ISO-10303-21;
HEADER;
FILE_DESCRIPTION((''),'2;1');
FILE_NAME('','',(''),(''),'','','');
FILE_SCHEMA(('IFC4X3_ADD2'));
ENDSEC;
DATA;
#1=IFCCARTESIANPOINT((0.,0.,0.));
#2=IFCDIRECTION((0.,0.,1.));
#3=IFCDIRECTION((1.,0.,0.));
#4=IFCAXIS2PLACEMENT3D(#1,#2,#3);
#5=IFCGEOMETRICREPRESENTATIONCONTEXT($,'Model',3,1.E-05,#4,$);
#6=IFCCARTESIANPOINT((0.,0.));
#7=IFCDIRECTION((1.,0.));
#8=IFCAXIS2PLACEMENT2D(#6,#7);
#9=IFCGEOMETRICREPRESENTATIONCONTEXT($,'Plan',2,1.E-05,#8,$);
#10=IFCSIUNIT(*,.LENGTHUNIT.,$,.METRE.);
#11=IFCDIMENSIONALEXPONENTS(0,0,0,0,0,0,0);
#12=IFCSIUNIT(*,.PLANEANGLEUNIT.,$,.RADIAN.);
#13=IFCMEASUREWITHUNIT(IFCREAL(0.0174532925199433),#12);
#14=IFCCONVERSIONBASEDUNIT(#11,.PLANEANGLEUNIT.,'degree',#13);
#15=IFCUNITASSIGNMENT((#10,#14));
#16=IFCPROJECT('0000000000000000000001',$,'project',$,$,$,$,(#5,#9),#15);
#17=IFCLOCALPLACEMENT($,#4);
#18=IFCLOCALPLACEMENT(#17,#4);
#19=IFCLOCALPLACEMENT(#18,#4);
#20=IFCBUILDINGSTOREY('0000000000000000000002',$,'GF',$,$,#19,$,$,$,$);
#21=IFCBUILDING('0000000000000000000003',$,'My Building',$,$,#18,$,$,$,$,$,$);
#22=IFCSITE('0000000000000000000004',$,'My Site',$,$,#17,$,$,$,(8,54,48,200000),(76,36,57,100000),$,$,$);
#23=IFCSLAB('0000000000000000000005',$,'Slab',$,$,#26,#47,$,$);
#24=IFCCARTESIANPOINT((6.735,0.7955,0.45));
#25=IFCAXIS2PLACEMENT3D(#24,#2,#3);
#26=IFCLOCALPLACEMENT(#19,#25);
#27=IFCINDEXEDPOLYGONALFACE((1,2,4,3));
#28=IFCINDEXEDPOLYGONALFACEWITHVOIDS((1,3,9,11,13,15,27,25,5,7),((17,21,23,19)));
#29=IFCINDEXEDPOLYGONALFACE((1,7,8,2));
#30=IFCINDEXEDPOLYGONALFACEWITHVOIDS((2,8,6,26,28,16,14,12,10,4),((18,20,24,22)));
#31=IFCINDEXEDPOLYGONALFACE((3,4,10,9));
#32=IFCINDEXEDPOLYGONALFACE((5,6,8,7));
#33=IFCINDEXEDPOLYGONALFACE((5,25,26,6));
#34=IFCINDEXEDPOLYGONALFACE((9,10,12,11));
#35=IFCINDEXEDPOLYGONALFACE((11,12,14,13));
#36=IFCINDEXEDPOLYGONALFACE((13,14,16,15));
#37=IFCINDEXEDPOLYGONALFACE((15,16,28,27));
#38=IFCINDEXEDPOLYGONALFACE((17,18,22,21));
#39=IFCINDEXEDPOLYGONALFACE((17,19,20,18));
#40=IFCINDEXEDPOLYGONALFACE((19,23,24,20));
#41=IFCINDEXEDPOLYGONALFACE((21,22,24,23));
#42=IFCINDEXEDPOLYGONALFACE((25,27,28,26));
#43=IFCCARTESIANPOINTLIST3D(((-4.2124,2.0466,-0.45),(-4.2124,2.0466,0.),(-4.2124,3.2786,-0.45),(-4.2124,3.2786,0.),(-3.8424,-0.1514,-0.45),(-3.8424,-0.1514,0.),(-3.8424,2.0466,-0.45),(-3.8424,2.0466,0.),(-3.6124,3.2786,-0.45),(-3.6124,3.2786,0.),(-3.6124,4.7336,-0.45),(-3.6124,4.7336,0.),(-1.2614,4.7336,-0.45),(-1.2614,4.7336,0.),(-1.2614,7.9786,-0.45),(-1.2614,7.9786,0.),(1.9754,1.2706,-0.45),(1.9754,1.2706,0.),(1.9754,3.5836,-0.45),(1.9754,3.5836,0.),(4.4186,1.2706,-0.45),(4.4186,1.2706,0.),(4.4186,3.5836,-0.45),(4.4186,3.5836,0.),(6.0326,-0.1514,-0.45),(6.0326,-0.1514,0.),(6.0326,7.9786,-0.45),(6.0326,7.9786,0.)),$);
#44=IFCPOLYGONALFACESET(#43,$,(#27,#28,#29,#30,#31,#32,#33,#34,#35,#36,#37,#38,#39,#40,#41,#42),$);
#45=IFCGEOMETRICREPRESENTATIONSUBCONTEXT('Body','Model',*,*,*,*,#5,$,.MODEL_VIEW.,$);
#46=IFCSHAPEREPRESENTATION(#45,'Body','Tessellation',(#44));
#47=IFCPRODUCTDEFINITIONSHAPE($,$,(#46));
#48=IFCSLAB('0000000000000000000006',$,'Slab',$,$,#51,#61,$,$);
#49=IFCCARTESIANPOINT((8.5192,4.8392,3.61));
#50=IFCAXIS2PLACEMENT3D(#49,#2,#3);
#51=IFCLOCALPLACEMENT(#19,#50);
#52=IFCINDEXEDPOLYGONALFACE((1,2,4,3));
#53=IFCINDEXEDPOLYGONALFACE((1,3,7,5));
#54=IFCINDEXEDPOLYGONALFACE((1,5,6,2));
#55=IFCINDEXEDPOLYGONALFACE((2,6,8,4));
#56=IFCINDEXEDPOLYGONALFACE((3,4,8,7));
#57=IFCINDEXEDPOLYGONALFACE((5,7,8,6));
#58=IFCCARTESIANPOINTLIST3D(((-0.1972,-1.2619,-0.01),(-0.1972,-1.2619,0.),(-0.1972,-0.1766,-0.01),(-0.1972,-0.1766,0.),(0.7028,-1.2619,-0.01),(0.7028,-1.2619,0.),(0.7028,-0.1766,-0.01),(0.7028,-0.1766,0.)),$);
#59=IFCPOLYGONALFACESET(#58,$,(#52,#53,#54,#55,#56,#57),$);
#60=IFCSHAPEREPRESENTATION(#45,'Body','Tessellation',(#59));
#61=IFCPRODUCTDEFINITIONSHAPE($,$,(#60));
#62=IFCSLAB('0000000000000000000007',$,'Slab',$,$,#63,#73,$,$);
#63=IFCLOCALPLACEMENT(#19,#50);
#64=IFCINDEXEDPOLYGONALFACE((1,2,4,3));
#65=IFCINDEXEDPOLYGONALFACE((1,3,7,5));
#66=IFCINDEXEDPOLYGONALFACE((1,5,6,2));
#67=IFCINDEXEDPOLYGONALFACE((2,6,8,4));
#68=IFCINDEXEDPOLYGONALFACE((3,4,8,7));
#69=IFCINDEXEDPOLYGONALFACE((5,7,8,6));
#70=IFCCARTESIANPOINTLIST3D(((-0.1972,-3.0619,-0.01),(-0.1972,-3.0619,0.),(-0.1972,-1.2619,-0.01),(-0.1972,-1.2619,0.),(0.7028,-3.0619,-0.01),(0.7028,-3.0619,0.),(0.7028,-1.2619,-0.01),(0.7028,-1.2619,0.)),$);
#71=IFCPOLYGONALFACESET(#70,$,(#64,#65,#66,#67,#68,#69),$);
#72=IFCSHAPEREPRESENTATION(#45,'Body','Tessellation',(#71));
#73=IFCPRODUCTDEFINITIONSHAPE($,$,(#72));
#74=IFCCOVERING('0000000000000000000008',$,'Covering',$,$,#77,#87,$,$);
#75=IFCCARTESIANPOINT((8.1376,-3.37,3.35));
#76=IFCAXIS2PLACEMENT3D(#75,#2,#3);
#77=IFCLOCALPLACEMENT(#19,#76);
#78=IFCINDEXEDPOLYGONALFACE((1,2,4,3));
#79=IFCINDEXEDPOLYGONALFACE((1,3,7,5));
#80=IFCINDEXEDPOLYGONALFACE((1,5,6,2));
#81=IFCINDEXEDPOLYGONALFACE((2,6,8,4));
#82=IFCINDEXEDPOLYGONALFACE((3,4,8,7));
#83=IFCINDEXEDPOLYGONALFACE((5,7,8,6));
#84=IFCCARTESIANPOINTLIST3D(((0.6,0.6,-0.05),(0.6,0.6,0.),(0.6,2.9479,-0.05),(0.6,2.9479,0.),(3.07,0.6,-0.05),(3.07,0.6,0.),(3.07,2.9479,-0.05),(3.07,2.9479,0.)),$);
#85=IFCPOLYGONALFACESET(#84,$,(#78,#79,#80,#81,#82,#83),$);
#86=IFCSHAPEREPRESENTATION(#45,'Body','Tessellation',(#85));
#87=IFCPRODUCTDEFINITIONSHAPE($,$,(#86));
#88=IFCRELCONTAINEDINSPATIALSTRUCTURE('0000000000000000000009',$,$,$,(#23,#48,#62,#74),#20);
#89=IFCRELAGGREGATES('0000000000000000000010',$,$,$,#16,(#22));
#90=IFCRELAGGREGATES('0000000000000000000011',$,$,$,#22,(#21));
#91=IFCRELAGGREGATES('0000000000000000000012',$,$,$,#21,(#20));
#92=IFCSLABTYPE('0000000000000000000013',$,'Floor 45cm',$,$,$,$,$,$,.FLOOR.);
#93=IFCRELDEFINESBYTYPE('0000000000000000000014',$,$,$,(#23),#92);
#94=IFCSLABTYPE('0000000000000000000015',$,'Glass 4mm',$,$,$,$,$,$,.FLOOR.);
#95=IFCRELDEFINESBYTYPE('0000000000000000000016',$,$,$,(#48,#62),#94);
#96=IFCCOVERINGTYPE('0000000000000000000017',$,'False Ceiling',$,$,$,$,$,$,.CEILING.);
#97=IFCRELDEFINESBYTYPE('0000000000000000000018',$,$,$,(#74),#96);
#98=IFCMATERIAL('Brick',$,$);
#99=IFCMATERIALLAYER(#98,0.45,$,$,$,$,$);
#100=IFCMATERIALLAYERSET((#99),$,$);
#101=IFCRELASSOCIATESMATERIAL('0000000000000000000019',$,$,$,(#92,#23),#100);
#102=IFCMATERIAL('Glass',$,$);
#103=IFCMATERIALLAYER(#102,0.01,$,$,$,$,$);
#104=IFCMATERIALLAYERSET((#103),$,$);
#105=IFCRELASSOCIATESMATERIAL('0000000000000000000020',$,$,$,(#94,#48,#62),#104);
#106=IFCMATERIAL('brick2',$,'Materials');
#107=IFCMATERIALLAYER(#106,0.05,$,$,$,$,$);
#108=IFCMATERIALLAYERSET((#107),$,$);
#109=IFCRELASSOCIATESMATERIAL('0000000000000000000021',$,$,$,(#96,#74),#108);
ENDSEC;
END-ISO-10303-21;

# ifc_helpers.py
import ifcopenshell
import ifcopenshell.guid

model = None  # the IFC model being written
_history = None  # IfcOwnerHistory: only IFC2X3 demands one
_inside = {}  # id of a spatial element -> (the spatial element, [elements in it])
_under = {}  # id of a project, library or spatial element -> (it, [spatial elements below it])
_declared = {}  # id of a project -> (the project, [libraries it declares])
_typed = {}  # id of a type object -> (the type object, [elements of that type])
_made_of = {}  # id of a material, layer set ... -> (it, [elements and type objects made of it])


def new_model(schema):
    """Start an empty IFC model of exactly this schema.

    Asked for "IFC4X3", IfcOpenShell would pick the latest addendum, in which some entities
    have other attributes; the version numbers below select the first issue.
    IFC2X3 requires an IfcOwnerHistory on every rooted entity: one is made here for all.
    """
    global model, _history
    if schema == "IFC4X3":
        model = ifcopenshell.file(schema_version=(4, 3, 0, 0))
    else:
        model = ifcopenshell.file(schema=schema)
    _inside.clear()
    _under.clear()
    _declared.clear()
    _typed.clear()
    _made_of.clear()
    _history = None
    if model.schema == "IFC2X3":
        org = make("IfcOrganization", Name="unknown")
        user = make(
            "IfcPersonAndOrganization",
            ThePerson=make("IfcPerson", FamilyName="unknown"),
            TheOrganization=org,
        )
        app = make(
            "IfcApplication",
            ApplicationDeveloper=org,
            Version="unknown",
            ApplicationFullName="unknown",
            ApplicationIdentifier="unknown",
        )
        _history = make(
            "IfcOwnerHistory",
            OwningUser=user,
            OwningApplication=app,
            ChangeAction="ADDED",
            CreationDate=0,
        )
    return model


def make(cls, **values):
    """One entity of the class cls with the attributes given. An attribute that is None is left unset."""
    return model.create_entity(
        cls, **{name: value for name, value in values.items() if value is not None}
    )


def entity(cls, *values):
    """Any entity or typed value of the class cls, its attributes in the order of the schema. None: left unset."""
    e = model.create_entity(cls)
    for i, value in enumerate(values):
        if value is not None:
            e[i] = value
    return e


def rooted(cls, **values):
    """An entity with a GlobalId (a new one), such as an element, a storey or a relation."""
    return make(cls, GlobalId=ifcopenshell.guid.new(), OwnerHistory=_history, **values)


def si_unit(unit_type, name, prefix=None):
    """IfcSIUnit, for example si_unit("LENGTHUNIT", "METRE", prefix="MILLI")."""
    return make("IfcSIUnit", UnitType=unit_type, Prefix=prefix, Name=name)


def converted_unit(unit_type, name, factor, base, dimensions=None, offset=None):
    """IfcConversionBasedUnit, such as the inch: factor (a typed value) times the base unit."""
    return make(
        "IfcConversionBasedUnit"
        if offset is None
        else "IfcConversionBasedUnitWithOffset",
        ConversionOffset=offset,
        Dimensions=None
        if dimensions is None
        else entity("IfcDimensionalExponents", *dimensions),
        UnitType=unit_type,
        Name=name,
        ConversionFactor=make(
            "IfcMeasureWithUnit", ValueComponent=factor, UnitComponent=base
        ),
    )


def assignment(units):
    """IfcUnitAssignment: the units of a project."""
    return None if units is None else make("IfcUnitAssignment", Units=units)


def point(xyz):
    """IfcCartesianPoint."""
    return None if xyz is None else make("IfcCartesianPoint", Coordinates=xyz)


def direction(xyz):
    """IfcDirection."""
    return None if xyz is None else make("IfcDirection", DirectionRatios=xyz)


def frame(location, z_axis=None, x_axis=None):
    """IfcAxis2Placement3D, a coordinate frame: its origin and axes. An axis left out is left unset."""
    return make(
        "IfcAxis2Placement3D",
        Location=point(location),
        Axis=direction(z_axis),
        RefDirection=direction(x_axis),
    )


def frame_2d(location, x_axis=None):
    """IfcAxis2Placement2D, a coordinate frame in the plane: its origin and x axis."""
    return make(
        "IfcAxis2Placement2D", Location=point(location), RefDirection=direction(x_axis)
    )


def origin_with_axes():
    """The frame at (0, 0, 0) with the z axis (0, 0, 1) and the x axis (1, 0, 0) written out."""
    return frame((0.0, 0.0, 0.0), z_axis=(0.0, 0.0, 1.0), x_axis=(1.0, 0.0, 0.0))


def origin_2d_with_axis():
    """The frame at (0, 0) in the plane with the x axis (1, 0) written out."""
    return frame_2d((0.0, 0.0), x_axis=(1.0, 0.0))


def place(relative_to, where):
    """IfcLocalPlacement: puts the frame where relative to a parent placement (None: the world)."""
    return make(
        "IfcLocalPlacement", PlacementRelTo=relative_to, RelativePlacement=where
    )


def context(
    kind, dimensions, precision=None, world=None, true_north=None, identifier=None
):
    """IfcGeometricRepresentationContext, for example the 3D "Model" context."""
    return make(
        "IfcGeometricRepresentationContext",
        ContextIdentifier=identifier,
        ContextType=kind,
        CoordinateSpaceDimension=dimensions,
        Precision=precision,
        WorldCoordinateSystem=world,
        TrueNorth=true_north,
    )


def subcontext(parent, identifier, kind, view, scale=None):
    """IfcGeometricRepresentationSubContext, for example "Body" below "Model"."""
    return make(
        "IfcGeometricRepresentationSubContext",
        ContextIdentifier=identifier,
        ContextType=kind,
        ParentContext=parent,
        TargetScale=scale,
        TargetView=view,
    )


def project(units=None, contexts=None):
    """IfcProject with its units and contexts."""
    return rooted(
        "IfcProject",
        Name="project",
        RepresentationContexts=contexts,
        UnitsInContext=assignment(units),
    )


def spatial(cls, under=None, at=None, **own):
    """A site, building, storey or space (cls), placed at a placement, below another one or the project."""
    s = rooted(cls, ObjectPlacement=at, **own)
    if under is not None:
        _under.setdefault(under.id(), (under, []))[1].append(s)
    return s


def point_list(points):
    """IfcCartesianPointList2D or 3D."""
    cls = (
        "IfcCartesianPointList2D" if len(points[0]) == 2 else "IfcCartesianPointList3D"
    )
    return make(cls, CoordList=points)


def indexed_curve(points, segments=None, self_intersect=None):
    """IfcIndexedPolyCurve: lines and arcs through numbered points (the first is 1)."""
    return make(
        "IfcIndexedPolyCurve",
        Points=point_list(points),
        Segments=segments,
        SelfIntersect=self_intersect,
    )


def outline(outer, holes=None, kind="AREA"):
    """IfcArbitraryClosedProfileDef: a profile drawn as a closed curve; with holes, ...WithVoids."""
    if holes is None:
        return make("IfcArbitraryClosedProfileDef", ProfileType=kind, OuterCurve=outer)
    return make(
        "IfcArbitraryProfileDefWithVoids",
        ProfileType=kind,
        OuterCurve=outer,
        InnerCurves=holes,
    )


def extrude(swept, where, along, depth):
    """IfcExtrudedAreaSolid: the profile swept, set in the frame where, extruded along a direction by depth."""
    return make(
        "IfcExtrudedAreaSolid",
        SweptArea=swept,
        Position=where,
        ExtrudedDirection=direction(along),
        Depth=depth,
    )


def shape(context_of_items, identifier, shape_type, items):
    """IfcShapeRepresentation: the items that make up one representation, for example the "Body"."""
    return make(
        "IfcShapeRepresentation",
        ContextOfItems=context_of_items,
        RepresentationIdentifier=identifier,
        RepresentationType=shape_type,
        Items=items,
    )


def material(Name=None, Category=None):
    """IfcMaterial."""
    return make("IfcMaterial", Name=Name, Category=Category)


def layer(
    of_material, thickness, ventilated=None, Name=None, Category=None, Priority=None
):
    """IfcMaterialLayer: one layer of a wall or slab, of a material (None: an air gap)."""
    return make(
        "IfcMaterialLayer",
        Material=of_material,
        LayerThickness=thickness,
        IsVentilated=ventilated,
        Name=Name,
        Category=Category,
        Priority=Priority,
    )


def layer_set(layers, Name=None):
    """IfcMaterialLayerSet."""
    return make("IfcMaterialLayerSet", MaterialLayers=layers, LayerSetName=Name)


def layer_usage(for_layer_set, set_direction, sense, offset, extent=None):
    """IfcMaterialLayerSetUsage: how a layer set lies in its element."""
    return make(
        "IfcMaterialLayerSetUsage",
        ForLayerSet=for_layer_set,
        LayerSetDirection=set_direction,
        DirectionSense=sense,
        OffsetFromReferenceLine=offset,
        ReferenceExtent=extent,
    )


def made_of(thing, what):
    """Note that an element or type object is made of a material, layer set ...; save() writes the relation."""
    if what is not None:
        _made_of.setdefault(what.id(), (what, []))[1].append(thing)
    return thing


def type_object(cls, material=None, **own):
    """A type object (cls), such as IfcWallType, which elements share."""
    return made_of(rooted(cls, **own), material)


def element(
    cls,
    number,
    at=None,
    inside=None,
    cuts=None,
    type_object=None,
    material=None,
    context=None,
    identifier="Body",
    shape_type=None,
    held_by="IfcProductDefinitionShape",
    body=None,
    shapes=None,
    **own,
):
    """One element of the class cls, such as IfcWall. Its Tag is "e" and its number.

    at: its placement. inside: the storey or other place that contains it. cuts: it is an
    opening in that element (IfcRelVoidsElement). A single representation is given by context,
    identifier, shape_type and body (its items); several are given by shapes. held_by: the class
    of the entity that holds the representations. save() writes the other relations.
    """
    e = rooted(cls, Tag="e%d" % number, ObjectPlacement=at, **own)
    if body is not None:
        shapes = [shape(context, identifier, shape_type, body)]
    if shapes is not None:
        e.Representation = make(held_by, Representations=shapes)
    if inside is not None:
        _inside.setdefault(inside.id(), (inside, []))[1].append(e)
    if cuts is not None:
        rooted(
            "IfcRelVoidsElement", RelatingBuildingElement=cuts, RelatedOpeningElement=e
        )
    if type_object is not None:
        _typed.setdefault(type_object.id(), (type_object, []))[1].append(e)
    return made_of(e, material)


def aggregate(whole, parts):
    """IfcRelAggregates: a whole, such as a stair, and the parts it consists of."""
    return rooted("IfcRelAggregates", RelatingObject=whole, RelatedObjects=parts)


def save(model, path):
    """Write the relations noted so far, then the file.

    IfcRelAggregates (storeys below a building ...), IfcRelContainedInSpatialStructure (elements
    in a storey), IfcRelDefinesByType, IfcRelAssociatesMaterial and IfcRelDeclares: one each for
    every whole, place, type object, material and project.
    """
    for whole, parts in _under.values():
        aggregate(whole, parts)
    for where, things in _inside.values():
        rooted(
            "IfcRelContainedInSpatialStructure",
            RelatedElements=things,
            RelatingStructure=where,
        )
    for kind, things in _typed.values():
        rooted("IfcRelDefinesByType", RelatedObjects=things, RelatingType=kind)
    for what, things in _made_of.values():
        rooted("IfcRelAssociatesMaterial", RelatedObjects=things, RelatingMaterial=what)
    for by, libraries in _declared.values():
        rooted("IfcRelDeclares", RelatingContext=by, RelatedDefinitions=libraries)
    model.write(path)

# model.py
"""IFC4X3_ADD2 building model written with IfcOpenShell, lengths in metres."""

from ifc_helpers import new_model, entity, si_unit, converted_unit, frame, origin_with_axes, origin_2d_with_axis, place, context, subcontext, project, spatial, indexed_curve, outline, extrude, material, layer, layer_set, layer_usage, type_object, element, save


model = new_model("IFC4X3_ADD2")

# Units and contexts
model_context = context("Model", 3, precision=1e-05, world=origin_with_axes())
plan_context = context("Plan", 2, precision=1e-05, world=origin_2d_with_axis())
body_context = subcontext(model_context, "Body", "Model", "MODEL_VIEW")
ifc_project = project(units=[si_unit("LENGTHUNIT", "METRE"), converted_unit("PLANEANGLEUNIT", "degree", entity("IfcReal", 0.0174532925199433), si_unit("PLANEANGLEUNIT", "RADIAN"), dimensions=[0, 0, 0, 0, 0, 0, 0])], contexts=[model_context, plan_context])

# Site, building, storey
site_placement = place(None, origin_with_axes())
site = spatial("IfcSite", under=ifc_project, at=site_placement, Name="My Site", RefLatitude=(8, 54, 48, 200000), RefLongitude=(76, 36, 57, 100000))
building_placement = place(site_placement, origin_with_axes())
building = spatial("IfcBuilding", under=site, at=building_placement, Name="My Building")
storey_placement = place(building_placement, origin_with_axes())
storey = spatial("IfcBuildingStorey", under=building, at=storey_placement, Name="GF")

# Slabs
ifc_material_1 = material(Name="Brick")
ifc_layer_1 = layer(ifc_material_1, 0.45)
ifc_layer_set_1 = layer_set([ifc_layer_1])
ifc_layer_usage_1 = layer_usage(ifc_layer_set_1, "AXIS3", "POSITIVE", -0.45)
slab_type_1 = type_object("IfcSlabType", Name="Floor 45cm", PredefinedType="FLOOR", material=ifc_layer_set_1)
slab_1_placement = place(storey_placement, frame((6.735, 0.7955, 0.45), z_axis=(0.0, 0.0, 1.0), x_axis=(1.0, 0.0, 0.0)))
element("IfcSlab", 1, at=slab_1_placement, inside=storey, type_object=slab_type_1, material=ifc_layer_usage_1, Name="Slab", context=body_context, shape_type="SweptSolid", body=[
    extrude(outline(indexed_curve([(-3.8424, -0.1514), (-3.8424, 2.0466), (-4.2124, 2.0466), (-4.2124, 3.2786), (-3.6124, 3.2786), (-3.6124, 4.7336), (-1.2614, 4.7336), (-1.2614, 7.9786), (6.0326, 7.9786), (6.0326, -0.1514), (-3.8424, -0.1514)]), holes=[indexed_curve([(4.4186, 1.2706), (1.9754, 1.2706), (1.9754, 3.5836), (4.4186, 3.5836), (4.4186, 1.2706)])]), frame((0.0, 0.0, -0.45), z_axis=(0.0, 0.0, 1.0), x_axis=(1.0, 0.0, 0.0)), (0.0, 0.0, 1.0), 0.45),
])
ifc_material_2 = material(Name="Glass")
ifc_layer_2 = layer(ifc_material_2, 0.01)
ifc_layer_set_2 = layer_set([ifc_layer_2])
ifc_layer_usage_2 = layer_usage(ifc_layer_set_2, "AXIS3", "POSITIVE", -0.01)
slab_type_2 = type_object("IfcSlabType", Name="Glass 4mm", PredefinedType="FLOOR", material=ifc_layer_set_2)
slab_2_placement = place(storey_placement, frame((8.5192, 4.8392, 3.61), z_axis=(0.0, 0.0, 1.0), x_axis=(1.0, 0.0, 0.0)))
element("IfcSlab", 2, at=slab_2_placement, inside=storey, type_object=slab_type_2, material=ifc_layer_usage_2, Name="Slab", context=body_context, shape_type="SweptSolid", body=[
    extrude(outline(indexed_curve([(-0.1972, -0.1766), (0.7028, -0.1766), (0.7028, -1.2619), (-0.1972, -1.2619), (-0.1972, -0.1766)])), frame((0.0, 0.0, -0.01), z_axis=(0.0, 0.0, 1.0), x_axis=(1.0, 0.0, 0.0)), (0.0, 0.0, 1.0), 0.01),
])
ifc_layer_usage_3 = layer_usage(ifc_layer_set_2, "AXIS3", "POSITIVE", -0.01)
slab_3_placement = place(storey_placement, frame((8.5192, 4.8392, 3.61), z_axis=(0.0, 0.0, 1.0), x_axis=(1.0, 0.0, 0.0)))
element("IfcSlab", 3, at=slab_3_placement, inside=storey, type_object=slab_type_2, material=ifc_layer_usage_3, Name="Slab", context=body_context, shape_type="SweptSolid", body=[
    extrude(outline(indexed_curve([(-0.1972, -3.0619), (0.7028, -3.0619), (0.7028, -1.2619), (-0.1972, -1.2619), (-0.1972, -3.0619)])), frame((0.0, 0.0, -0.01), z_axis=(0.0, 0.0, 1.0), x_axis=(1.0, 0.0, 0.0)), (0.0, 0.0, 1.0), 0.01),
])

# Covering
ifc_material_3 = material(Name="brick2", Category="Materials")
ifc_layer_3 = layer(ifc_material_3, 0.05)
ifc_layer_set_3 = layer_set([ifc_layer_3])
covering_type_1 = type_object("IfcCoveringType", Name="False Ceiling", PredefinedType="CEILING", material=ifc_layer_set_3)
ifc_layer_usage_4 = layer_usage(ifc_layer_set_3, "AXIS3", "POSITIVE", -0.05)
covering_1_placement = place(storey_placement, frame((8.1376, -3.37, 3.35), z_axis=(0.0, 0.0, 1.0), x_axis=(1.0, 0.0, 0.0)))
element("IfcCovering", 4, at=covering_1_placement, inside=storey, type_object=covering_type_1, material=ifc_layer_usage_4, Name="Covering", context=body_context, shape_type="SweptSolid", body=[
    extrude(outline(indexed_curve([(0.6, 0.6), (3.07, 0.6), (3.07, 2.9479), (0.6, 2.9479), (0.6, 0.6)])), frame((0.0, 0.0, -0.05), z_axis=(0.0, 0.0, 1.0), x_axis=(1.0, 0.0, 0.0)), (0.0, 0.0, 1.0), 0.05),
])

save(model, "model.ifc")
